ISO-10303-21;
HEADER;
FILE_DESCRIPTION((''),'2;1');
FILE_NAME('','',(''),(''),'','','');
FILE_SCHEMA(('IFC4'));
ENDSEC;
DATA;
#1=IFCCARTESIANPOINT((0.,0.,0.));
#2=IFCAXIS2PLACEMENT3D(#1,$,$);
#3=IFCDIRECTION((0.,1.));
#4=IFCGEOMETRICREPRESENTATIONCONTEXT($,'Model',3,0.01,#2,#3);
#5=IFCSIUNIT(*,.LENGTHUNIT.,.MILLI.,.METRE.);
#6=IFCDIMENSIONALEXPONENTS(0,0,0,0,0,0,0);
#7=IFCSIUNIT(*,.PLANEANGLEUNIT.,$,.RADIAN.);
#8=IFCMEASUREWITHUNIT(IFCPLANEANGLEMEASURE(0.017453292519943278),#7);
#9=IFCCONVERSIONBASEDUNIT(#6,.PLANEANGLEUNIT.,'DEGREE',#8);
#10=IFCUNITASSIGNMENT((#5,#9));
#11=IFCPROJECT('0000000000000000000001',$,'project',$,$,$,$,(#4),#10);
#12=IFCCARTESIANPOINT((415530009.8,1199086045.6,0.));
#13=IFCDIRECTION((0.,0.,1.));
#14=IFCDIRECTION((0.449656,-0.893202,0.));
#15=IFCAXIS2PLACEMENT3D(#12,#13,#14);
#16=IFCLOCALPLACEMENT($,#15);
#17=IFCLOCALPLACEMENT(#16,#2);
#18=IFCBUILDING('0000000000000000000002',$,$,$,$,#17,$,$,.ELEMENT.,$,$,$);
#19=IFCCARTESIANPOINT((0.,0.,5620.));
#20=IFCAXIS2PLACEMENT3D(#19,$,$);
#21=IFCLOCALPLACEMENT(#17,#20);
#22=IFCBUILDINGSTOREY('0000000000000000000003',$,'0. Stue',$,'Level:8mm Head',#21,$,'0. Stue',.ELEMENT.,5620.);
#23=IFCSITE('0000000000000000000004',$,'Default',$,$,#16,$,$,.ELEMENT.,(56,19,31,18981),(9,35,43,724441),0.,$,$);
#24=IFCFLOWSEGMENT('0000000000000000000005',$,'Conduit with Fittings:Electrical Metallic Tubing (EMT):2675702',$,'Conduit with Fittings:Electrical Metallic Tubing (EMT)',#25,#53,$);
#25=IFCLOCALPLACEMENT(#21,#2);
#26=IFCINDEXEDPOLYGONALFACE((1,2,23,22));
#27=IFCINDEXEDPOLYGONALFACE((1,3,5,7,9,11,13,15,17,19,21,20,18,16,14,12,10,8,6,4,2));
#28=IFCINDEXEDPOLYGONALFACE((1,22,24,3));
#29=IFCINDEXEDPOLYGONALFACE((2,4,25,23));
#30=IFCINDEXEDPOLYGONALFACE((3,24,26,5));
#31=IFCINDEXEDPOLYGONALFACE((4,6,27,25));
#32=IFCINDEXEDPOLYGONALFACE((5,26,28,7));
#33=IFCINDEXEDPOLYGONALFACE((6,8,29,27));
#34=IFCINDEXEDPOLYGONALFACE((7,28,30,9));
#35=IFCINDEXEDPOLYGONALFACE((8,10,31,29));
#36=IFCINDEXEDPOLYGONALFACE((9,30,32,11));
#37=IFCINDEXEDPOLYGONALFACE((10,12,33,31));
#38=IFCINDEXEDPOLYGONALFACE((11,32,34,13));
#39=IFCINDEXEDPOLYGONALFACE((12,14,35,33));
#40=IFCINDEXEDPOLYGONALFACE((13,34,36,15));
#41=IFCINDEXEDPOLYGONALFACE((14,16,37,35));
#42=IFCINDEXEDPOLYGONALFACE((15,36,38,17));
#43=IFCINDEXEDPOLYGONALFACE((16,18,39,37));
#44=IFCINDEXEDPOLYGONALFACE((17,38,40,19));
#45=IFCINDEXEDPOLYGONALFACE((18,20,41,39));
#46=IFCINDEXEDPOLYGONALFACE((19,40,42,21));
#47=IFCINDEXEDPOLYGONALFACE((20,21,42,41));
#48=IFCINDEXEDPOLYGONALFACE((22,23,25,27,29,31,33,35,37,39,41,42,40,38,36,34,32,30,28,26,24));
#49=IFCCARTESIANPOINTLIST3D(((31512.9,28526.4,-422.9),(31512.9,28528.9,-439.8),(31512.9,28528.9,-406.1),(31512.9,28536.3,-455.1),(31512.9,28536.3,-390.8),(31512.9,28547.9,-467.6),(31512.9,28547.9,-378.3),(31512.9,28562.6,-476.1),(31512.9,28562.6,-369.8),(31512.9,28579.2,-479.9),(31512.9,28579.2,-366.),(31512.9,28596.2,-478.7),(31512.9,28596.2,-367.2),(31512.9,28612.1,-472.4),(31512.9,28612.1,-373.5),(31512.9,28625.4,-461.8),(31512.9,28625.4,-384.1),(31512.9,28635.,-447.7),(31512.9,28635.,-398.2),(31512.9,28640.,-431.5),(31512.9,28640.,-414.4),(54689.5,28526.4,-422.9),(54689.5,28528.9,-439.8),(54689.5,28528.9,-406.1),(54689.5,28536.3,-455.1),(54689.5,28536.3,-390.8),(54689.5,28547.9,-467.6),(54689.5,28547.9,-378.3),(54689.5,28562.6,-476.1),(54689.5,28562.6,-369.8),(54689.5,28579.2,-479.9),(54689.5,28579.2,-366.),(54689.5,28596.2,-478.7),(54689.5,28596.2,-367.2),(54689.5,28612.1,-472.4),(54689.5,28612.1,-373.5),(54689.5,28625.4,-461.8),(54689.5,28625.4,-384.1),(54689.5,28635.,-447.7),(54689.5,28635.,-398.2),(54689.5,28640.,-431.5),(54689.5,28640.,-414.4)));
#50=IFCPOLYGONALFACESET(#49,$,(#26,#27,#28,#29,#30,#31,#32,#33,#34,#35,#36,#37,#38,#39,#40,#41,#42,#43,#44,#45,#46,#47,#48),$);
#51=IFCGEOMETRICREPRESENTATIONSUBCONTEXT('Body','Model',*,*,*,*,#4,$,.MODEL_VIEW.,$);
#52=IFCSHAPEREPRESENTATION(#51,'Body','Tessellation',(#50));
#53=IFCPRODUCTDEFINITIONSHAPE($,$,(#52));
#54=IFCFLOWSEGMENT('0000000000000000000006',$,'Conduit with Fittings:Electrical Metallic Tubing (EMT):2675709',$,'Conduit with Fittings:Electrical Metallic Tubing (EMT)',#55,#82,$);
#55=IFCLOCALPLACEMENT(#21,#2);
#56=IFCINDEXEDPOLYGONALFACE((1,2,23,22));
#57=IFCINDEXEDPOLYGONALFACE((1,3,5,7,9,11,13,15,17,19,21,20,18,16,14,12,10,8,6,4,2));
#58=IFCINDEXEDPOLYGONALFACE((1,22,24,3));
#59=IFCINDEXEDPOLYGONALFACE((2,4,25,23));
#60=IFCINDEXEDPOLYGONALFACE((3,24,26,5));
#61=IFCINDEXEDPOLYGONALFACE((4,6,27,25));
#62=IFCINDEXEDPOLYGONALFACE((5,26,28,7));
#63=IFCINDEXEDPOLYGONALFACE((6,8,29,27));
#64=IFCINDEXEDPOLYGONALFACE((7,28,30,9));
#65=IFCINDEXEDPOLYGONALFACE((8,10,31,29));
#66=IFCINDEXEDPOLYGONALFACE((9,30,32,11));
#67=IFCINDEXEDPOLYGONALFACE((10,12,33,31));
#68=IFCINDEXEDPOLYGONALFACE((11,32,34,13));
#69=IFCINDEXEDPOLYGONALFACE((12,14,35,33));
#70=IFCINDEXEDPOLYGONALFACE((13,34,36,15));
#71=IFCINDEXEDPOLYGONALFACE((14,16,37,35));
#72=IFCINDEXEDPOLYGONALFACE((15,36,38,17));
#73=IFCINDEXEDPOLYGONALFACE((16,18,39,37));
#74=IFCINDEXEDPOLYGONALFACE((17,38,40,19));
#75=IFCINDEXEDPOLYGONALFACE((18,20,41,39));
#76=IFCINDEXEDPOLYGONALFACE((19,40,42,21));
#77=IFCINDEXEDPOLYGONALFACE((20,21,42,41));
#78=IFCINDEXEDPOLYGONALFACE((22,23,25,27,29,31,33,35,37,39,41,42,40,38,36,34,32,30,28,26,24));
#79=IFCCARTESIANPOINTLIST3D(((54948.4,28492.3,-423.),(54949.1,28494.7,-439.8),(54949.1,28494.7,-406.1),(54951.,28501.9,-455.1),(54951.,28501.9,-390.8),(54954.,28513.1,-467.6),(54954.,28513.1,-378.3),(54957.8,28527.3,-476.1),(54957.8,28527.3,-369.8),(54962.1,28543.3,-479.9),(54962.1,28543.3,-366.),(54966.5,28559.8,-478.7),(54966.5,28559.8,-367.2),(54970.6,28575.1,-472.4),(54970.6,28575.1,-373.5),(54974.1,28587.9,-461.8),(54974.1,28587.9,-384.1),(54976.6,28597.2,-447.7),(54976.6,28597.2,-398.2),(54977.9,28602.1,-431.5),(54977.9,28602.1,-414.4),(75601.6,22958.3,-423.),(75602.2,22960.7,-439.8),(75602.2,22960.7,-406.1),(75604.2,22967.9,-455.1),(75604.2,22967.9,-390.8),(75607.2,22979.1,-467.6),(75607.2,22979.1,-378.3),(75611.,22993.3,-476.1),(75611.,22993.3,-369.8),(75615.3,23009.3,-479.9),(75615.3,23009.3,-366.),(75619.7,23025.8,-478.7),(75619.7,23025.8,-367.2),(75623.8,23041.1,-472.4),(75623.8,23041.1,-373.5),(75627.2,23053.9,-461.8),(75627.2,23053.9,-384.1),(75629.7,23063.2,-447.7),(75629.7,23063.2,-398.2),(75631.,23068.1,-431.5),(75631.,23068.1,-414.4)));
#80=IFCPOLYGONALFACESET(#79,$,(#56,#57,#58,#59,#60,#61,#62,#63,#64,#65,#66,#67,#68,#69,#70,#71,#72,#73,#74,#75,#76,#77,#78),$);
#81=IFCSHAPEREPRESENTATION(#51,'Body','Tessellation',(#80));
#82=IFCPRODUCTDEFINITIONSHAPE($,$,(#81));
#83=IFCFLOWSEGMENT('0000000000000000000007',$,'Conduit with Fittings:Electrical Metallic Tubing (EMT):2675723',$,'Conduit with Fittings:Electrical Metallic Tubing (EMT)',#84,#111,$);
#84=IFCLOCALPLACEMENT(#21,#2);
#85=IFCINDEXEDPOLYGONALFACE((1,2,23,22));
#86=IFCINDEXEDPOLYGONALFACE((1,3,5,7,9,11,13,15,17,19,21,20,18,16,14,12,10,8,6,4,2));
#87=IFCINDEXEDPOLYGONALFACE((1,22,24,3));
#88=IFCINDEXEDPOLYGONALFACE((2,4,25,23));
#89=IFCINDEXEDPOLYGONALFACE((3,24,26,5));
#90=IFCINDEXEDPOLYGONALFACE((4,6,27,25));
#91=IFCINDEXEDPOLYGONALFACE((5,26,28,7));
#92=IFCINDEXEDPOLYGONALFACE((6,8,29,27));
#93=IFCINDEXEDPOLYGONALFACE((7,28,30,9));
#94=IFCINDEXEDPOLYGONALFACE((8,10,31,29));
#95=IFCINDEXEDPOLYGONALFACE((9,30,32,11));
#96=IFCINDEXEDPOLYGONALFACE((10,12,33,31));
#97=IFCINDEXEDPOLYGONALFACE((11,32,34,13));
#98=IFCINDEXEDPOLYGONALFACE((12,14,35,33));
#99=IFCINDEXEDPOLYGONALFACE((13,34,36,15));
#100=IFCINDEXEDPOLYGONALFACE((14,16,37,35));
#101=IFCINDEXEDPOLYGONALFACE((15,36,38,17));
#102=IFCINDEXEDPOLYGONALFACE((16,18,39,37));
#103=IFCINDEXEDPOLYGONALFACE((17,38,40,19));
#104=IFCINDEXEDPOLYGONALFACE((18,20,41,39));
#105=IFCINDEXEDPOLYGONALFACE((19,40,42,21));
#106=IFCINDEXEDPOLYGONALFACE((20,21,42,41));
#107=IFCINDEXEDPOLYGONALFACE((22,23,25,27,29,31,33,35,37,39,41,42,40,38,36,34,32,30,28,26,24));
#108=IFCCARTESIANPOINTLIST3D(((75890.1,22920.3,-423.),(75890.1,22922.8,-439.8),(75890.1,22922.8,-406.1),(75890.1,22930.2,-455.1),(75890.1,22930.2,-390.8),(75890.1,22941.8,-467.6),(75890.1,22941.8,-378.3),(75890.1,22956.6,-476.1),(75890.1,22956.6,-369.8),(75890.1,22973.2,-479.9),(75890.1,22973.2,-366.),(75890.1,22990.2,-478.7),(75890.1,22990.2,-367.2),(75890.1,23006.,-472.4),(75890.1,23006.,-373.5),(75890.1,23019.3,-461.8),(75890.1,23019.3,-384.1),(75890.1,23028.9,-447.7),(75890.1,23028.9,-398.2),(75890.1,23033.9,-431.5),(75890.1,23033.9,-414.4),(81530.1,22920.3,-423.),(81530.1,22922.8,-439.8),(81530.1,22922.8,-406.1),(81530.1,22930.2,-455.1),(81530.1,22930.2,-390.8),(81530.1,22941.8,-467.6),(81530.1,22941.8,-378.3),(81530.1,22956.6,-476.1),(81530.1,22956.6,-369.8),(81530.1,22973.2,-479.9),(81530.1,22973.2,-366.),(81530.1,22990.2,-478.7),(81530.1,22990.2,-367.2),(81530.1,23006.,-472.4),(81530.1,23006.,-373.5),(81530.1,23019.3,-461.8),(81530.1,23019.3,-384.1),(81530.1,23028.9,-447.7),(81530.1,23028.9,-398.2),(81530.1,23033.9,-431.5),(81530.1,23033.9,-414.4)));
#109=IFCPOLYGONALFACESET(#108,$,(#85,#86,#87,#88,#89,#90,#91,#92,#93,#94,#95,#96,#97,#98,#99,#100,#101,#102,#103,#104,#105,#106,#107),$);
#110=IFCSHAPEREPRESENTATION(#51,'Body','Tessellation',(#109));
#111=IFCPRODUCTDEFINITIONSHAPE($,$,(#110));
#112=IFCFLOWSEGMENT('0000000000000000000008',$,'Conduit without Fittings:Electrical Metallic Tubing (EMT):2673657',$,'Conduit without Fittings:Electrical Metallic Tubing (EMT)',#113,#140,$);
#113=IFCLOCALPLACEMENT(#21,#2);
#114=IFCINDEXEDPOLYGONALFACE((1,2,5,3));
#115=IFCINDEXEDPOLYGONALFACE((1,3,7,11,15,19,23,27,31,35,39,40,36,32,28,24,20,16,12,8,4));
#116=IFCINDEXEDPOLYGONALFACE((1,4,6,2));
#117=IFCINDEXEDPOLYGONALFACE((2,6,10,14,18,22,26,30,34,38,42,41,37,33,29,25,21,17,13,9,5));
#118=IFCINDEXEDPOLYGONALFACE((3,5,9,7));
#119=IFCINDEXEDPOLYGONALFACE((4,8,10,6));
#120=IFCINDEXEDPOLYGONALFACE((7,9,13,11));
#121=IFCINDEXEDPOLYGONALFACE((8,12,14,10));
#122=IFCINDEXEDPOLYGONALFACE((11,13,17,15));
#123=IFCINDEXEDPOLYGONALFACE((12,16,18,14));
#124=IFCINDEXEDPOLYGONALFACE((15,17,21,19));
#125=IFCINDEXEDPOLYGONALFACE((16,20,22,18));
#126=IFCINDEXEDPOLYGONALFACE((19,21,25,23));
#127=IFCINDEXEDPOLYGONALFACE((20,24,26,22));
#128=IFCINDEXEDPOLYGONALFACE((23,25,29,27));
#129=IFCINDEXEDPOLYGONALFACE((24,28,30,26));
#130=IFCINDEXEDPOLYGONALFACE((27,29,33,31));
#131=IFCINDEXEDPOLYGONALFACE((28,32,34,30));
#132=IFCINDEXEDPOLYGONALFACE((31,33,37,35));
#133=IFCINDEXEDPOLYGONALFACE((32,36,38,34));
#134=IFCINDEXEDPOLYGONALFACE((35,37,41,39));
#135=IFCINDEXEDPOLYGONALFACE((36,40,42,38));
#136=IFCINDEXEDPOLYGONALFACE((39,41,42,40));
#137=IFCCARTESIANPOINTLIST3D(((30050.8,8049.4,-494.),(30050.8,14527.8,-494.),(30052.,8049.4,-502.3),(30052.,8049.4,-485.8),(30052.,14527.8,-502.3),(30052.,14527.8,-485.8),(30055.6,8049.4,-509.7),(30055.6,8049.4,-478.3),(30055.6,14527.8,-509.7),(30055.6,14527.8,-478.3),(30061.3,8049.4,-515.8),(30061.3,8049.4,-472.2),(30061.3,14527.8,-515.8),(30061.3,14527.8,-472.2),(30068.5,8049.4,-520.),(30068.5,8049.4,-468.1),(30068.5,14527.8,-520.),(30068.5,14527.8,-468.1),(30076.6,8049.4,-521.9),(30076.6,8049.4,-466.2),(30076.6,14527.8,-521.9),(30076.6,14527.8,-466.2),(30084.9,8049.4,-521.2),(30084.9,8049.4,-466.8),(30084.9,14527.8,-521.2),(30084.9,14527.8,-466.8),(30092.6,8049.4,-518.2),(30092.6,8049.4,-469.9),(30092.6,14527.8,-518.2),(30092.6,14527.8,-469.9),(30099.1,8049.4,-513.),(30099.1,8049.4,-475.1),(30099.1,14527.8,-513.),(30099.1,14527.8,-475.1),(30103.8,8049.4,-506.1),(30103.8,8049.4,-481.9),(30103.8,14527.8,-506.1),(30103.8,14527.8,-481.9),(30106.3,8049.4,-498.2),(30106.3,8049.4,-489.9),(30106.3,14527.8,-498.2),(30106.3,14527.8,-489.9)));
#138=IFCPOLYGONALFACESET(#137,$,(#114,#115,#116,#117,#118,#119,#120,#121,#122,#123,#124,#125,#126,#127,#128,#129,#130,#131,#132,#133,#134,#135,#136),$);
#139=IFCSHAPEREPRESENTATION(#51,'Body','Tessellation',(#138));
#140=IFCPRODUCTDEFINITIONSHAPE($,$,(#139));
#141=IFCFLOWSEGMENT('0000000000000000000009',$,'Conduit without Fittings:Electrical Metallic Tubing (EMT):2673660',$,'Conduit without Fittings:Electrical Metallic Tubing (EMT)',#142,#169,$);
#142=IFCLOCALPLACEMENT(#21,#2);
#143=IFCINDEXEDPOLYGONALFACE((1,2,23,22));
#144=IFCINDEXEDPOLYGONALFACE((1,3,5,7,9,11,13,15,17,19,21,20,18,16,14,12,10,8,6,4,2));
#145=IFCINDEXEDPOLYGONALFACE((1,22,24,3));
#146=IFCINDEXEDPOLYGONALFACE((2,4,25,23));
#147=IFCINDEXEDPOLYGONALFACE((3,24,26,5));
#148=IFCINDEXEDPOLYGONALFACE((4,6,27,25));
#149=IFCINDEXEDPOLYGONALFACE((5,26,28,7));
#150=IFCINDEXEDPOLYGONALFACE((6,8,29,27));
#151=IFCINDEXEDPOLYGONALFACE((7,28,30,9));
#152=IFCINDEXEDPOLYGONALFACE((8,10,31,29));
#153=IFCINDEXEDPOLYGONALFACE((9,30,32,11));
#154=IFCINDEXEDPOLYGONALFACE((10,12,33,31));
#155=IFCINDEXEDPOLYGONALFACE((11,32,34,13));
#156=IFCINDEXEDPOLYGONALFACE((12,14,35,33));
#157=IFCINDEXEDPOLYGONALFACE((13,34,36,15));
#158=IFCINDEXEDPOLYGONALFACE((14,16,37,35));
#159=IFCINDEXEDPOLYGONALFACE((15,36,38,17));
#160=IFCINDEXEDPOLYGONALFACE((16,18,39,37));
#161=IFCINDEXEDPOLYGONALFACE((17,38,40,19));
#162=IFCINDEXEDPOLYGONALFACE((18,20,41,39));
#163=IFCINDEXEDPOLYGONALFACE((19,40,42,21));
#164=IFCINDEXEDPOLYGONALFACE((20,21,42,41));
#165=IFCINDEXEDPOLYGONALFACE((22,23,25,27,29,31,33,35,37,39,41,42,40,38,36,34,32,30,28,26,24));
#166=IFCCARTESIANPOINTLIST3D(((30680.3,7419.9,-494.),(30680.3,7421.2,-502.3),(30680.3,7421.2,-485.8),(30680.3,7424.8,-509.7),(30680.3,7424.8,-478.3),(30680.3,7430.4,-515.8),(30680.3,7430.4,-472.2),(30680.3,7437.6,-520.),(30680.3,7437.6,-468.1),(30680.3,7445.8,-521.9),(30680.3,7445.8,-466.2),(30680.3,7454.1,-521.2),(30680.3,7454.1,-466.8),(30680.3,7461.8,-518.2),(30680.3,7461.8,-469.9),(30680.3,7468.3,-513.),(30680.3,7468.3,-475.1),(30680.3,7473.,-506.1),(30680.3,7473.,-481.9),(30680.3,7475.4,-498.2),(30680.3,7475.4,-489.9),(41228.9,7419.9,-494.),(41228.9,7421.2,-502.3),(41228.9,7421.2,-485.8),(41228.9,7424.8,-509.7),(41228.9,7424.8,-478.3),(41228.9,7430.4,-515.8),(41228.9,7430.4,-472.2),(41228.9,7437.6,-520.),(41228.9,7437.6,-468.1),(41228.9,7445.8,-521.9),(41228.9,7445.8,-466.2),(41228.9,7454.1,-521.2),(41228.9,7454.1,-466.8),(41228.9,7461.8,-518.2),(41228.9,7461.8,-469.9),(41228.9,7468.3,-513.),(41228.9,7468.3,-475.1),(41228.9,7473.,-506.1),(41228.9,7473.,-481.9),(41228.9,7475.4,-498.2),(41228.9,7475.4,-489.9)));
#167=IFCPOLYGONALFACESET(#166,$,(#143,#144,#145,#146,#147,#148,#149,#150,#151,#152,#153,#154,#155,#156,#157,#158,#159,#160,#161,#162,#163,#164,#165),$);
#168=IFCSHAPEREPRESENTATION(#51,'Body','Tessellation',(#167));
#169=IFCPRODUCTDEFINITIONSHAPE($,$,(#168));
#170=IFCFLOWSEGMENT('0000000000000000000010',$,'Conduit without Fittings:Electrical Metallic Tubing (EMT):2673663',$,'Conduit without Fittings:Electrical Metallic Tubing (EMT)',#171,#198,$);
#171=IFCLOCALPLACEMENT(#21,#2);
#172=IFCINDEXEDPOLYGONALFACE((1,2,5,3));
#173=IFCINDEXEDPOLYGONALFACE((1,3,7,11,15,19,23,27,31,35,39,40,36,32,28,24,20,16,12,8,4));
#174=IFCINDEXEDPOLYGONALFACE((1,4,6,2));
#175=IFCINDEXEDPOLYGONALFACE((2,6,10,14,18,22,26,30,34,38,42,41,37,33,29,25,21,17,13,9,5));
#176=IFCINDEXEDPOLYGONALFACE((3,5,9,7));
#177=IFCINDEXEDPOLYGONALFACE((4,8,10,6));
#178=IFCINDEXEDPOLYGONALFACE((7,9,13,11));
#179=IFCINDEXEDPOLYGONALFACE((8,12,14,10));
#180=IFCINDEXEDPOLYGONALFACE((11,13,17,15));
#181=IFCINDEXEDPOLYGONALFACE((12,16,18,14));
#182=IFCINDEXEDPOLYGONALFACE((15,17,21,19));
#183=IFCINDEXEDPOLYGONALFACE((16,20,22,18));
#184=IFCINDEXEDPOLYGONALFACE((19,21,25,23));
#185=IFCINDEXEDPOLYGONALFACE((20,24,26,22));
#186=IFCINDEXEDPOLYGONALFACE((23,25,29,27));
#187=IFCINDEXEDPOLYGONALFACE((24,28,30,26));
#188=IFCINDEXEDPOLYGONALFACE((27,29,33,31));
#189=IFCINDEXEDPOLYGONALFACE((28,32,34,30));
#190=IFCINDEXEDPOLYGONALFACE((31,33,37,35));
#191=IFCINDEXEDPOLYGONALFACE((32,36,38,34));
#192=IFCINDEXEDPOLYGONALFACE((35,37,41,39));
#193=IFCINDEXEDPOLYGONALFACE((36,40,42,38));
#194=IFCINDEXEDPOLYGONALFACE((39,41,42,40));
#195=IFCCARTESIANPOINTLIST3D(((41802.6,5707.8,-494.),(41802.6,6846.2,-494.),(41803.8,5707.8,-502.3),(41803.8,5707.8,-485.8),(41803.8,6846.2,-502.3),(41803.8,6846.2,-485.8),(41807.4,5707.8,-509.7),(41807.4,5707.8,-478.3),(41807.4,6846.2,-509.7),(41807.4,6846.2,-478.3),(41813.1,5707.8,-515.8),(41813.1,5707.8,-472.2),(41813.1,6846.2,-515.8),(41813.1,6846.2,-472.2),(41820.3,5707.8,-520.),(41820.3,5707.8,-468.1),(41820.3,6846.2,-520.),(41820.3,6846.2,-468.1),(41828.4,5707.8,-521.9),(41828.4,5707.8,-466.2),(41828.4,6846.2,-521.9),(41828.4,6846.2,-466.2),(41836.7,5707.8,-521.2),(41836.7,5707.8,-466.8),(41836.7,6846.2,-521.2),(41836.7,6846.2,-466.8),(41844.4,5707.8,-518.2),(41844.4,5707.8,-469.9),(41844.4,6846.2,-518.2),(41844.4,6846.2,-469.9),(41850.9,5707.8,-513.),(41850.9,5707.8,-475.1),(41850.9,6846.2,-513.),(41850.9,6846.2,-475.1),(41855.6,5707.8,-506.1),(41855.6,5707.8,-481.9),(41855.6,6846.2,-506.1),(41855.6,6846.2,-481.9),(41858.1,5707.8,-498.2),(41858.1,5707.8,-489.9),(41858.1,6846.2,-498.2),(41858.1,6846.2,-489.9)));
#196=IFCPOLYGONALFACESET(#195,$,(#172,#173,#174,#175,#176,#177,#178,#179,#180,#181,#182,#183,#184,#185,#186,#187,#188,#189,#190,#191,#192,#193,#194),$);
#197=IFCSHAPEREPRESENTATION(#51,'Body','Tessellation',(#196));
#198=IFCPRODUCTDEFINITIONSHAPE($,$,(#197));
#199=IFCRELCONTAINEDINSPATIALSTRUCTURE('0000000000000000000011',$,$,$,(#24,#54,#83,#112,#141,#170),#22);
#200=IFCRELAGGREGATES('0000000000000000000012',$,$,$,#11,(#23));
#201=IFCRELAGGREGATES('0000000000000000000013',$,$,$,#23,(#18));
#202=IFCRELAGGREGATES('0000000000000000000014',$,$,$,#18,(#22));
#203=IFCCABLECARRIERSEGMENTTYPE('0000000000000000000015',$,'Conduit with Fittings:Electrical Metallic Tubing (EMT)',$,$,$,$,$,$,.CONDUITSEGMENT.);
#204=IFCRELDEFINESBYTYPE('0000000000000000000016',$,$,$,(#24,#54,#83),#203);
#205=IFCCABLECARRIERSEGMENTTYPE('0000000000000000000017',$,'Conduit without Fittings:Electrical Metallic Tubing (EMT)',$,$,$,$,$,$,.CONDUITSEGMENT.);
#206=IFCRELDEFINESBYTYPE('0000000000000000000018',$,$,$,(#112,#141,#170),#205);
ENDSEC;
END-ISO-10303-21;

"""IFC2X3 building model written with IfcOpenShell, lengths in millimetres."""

from ifc_helpers import new_model, entity, si_unit, converted_unit, direction, frame, frame_2d, origin, origin_2d_with_axis, place, context, subcontext, project, spatial, circle, extrude, type_object, element, save


model = new_model("IFC2X3")

# Units and contexts
model_context = context("Model", 3, precision=0.01, world=origin(), true_north=direction((0.0, 1.0)))
body_context = subcontext(model_context, "Body", "Model", "MODEL_VIEW")
ifc_project = project(units=[si_unit("LENGTHUNIT", "METRE", prefix="MILLI"), converted_unit("PLANEANGLEUNIT", "DEGREE", entity("IfcPlaneAngleMeasure", 0.017453292519943278), si_unit("PLANEANGLEUNIT", "RADIAN"), dimensions=[0, 0, 0, 0, 0, 0, 0])], contexts=[model_context])

# Site, building, storey
site_placement = place(None, frame((415530009.8, 1199086045.6, 0.0), z_axis=(0.0, 0.0, 1.0), x_axis=(0.449656, -0.893202, 0.0)))
site = spatial("IfcSite", under=ifc_project, at=site_placement, Name="Default", CompositionType="ELEMENT", RefLatitude=(56, 19, 31, 18981), RefLongitude=(9, 35, 43, 724441), RefElevation=0.0)
building_placement = place(site_placement, origin())
building = spatial("IfcBuilding", under=site, at=building_placement, CompositionType="ELEMENT")
storey_placement = place(building_placement, frame((0.0, 0.0, 5620.0)))
storey = spatial("IfcBuildingStorey", under=building, at=storey_placement, Name="0. Stue", ObjectType="Level:8mm Head", LongName="0. Stue", CompositionType="ELEMENT", Elevation=5620.0)

# Flow segments
cable_carrier_segment_type_1 = type_object("IfcCableCarrierSegmentType", Name="Conduit with Fittings:Electrical Metallic Tubing (EMT)", PredefinedType="CONDUITSEGMENT")
flow_segment_1_placement = place(storey_placement, origin())
element("IfcFlowSegment", 1, at=flow_segment_1_placement, inside=storey, type_object=cable_carrier_segment_type_1, Name="Conduit with Fittings:Electrical Metallic Tubing (EMT):2675702", ObjectType="Conduit with Fittings:Electrical Metallic Tubing (EMT)", context=body_context, shape_type="SweptSolid", body=[
    extrude(circle(Radius=57.2, at=origin_2d_with_axis()), frame((31512.9, 28583.5, -423.0), z_axis=(1.0, 0.0, 0.0), x_axis=(0.0, -1.0, 0.0)), (0.0, 0.0, 1.0), 23176.7),
])
flow_segment_2_placement = place(storey_placement, origin())
element("IfcFlowSegment", 2, at=flow_segment_2_placement, inside=storey, type_object=cable_carrier_segment_type_1, Name="Conduit with Fittings:Electrical Metallic Tubing (EMT):2675709", ObjectType="Conduit with Fittings:Electrical Metallic Tubing (EMT)", context=body_context, shape_type="SweptSolid", body=[
    extrude(circle(Radius=57.2, at=origin_2d_with_axis()), frame((54963.2, 28547.5, -423.0), z_axis=(0.965926, -0.258819, 0.0), x_axis=(-0.258819, -0.965926, 0.0)), (0.0, 0.0, 1.0), 21381.7),
])
flow_segment_3_placement = place(storey_placement, origin())
element("IfcFlowSegment", 3, at=flow_segment_3_placement, inside=storey, type_object=cable_carrier_segment_type_1, Name="Conduit with Fittings:Electrical Metallic Tubing (EMT):2675723", ObjectType="Conduit with Fittings:Electrical Metallic Tubing (EMT)", context=body_context, shape_type="SweptSolid", body=[
    extrude(circle(Radius=57.2, at=origin_2d_with_axis()), frame((75890.1, 22977.4, -423.0), z_axis=(1.0, 0.0, 0.0), x_axis=(0.0, -1.0, 0.0)), (0.0, 0.0, 1.0), 5640.0),
])
cable_carrier_segment_type_2 = type_object("IfcCableCarrierSegmentType", Name="Conduit without Fittings:Electrical Metallic Tubing (EMT)", PredefinedType="CONDUITSEGMENT")
flow_segment_4_placement = place(storey_placement, origin())
element("IfcFlowSegment", 4, at=flow_segment_4_placement, inside=storey, type_object=cable_carrier_segment_type_2, Name="Conduit without Fittings:Electrical Metallic Tubing (EMT):2673657", ObjectType="Conduit without Fittings:Electrical Metallic Tubing (EMT)", context=body_context, shape_type="SweptSolid", body=[
    extrude(circle(Radius=27.9, at=frame_2d((0.0, 0.0), x_axis=(1.0, 0.0))), frame((30078.7, 8049.4, -494.0), z_axis=(0.0, 1.0, 0.0), x_axis=(-1.0, 0.0, 0.0)), (0.0, 0.0, 1.0), 6478.4),
])
flow_segment_5_placement = place(storey_placement, origin())
element("IfcFlowSegment", 5, at=flow_segment_5_placement, inside=storey, type_object=cable_carrier_segment_type_2, Name="Conduit without Fittings:Electrical Metallic Tubing (EMT):2673660", ObjectType="Conduit without Fittings:Electrical Metallic Tubing (EMT)", context=body_context, shape_type="SweptSolid", body=[
    extrude(circle(Radius=27.9, at=origin_2d_with_axis()), frame((30680.3, 7447.8, -494.0), z_axis=(1.0, 0.0, 0.0), x_axis=(0.0, -1.0, 0.0)), (0.0, 0.0, 1.0), 10548.6),
])
flow_segment_6_placement = place(storey_placement, origin())
element("IfcFlowSegment", 6, at=flow_segment_6_placement, inside=storey, type_object=cable_carrier_segment_type_2, Name="Conduit without Fittings:Electrical Metallic Tubing (EMT):2673663", ObjectType="Conduit without Fittings:Electrical Metallic Tubing (EMT)", context=body_context, shape_type="SweptSolid", body=[
    extrude(circle(Radius=27.9, at=frame_2d((0.0, 0.0), x_axis=(1.0, 0.0))), frame((41830.5, 5707.8, -494.0), z_axis=(0.0, 1.0, 0.0), x_axis=(-1.0, 0.0, 0.0)), (0.0, 0.0, 1.0), 1138.4),
])

save(model, "model.ifc")
